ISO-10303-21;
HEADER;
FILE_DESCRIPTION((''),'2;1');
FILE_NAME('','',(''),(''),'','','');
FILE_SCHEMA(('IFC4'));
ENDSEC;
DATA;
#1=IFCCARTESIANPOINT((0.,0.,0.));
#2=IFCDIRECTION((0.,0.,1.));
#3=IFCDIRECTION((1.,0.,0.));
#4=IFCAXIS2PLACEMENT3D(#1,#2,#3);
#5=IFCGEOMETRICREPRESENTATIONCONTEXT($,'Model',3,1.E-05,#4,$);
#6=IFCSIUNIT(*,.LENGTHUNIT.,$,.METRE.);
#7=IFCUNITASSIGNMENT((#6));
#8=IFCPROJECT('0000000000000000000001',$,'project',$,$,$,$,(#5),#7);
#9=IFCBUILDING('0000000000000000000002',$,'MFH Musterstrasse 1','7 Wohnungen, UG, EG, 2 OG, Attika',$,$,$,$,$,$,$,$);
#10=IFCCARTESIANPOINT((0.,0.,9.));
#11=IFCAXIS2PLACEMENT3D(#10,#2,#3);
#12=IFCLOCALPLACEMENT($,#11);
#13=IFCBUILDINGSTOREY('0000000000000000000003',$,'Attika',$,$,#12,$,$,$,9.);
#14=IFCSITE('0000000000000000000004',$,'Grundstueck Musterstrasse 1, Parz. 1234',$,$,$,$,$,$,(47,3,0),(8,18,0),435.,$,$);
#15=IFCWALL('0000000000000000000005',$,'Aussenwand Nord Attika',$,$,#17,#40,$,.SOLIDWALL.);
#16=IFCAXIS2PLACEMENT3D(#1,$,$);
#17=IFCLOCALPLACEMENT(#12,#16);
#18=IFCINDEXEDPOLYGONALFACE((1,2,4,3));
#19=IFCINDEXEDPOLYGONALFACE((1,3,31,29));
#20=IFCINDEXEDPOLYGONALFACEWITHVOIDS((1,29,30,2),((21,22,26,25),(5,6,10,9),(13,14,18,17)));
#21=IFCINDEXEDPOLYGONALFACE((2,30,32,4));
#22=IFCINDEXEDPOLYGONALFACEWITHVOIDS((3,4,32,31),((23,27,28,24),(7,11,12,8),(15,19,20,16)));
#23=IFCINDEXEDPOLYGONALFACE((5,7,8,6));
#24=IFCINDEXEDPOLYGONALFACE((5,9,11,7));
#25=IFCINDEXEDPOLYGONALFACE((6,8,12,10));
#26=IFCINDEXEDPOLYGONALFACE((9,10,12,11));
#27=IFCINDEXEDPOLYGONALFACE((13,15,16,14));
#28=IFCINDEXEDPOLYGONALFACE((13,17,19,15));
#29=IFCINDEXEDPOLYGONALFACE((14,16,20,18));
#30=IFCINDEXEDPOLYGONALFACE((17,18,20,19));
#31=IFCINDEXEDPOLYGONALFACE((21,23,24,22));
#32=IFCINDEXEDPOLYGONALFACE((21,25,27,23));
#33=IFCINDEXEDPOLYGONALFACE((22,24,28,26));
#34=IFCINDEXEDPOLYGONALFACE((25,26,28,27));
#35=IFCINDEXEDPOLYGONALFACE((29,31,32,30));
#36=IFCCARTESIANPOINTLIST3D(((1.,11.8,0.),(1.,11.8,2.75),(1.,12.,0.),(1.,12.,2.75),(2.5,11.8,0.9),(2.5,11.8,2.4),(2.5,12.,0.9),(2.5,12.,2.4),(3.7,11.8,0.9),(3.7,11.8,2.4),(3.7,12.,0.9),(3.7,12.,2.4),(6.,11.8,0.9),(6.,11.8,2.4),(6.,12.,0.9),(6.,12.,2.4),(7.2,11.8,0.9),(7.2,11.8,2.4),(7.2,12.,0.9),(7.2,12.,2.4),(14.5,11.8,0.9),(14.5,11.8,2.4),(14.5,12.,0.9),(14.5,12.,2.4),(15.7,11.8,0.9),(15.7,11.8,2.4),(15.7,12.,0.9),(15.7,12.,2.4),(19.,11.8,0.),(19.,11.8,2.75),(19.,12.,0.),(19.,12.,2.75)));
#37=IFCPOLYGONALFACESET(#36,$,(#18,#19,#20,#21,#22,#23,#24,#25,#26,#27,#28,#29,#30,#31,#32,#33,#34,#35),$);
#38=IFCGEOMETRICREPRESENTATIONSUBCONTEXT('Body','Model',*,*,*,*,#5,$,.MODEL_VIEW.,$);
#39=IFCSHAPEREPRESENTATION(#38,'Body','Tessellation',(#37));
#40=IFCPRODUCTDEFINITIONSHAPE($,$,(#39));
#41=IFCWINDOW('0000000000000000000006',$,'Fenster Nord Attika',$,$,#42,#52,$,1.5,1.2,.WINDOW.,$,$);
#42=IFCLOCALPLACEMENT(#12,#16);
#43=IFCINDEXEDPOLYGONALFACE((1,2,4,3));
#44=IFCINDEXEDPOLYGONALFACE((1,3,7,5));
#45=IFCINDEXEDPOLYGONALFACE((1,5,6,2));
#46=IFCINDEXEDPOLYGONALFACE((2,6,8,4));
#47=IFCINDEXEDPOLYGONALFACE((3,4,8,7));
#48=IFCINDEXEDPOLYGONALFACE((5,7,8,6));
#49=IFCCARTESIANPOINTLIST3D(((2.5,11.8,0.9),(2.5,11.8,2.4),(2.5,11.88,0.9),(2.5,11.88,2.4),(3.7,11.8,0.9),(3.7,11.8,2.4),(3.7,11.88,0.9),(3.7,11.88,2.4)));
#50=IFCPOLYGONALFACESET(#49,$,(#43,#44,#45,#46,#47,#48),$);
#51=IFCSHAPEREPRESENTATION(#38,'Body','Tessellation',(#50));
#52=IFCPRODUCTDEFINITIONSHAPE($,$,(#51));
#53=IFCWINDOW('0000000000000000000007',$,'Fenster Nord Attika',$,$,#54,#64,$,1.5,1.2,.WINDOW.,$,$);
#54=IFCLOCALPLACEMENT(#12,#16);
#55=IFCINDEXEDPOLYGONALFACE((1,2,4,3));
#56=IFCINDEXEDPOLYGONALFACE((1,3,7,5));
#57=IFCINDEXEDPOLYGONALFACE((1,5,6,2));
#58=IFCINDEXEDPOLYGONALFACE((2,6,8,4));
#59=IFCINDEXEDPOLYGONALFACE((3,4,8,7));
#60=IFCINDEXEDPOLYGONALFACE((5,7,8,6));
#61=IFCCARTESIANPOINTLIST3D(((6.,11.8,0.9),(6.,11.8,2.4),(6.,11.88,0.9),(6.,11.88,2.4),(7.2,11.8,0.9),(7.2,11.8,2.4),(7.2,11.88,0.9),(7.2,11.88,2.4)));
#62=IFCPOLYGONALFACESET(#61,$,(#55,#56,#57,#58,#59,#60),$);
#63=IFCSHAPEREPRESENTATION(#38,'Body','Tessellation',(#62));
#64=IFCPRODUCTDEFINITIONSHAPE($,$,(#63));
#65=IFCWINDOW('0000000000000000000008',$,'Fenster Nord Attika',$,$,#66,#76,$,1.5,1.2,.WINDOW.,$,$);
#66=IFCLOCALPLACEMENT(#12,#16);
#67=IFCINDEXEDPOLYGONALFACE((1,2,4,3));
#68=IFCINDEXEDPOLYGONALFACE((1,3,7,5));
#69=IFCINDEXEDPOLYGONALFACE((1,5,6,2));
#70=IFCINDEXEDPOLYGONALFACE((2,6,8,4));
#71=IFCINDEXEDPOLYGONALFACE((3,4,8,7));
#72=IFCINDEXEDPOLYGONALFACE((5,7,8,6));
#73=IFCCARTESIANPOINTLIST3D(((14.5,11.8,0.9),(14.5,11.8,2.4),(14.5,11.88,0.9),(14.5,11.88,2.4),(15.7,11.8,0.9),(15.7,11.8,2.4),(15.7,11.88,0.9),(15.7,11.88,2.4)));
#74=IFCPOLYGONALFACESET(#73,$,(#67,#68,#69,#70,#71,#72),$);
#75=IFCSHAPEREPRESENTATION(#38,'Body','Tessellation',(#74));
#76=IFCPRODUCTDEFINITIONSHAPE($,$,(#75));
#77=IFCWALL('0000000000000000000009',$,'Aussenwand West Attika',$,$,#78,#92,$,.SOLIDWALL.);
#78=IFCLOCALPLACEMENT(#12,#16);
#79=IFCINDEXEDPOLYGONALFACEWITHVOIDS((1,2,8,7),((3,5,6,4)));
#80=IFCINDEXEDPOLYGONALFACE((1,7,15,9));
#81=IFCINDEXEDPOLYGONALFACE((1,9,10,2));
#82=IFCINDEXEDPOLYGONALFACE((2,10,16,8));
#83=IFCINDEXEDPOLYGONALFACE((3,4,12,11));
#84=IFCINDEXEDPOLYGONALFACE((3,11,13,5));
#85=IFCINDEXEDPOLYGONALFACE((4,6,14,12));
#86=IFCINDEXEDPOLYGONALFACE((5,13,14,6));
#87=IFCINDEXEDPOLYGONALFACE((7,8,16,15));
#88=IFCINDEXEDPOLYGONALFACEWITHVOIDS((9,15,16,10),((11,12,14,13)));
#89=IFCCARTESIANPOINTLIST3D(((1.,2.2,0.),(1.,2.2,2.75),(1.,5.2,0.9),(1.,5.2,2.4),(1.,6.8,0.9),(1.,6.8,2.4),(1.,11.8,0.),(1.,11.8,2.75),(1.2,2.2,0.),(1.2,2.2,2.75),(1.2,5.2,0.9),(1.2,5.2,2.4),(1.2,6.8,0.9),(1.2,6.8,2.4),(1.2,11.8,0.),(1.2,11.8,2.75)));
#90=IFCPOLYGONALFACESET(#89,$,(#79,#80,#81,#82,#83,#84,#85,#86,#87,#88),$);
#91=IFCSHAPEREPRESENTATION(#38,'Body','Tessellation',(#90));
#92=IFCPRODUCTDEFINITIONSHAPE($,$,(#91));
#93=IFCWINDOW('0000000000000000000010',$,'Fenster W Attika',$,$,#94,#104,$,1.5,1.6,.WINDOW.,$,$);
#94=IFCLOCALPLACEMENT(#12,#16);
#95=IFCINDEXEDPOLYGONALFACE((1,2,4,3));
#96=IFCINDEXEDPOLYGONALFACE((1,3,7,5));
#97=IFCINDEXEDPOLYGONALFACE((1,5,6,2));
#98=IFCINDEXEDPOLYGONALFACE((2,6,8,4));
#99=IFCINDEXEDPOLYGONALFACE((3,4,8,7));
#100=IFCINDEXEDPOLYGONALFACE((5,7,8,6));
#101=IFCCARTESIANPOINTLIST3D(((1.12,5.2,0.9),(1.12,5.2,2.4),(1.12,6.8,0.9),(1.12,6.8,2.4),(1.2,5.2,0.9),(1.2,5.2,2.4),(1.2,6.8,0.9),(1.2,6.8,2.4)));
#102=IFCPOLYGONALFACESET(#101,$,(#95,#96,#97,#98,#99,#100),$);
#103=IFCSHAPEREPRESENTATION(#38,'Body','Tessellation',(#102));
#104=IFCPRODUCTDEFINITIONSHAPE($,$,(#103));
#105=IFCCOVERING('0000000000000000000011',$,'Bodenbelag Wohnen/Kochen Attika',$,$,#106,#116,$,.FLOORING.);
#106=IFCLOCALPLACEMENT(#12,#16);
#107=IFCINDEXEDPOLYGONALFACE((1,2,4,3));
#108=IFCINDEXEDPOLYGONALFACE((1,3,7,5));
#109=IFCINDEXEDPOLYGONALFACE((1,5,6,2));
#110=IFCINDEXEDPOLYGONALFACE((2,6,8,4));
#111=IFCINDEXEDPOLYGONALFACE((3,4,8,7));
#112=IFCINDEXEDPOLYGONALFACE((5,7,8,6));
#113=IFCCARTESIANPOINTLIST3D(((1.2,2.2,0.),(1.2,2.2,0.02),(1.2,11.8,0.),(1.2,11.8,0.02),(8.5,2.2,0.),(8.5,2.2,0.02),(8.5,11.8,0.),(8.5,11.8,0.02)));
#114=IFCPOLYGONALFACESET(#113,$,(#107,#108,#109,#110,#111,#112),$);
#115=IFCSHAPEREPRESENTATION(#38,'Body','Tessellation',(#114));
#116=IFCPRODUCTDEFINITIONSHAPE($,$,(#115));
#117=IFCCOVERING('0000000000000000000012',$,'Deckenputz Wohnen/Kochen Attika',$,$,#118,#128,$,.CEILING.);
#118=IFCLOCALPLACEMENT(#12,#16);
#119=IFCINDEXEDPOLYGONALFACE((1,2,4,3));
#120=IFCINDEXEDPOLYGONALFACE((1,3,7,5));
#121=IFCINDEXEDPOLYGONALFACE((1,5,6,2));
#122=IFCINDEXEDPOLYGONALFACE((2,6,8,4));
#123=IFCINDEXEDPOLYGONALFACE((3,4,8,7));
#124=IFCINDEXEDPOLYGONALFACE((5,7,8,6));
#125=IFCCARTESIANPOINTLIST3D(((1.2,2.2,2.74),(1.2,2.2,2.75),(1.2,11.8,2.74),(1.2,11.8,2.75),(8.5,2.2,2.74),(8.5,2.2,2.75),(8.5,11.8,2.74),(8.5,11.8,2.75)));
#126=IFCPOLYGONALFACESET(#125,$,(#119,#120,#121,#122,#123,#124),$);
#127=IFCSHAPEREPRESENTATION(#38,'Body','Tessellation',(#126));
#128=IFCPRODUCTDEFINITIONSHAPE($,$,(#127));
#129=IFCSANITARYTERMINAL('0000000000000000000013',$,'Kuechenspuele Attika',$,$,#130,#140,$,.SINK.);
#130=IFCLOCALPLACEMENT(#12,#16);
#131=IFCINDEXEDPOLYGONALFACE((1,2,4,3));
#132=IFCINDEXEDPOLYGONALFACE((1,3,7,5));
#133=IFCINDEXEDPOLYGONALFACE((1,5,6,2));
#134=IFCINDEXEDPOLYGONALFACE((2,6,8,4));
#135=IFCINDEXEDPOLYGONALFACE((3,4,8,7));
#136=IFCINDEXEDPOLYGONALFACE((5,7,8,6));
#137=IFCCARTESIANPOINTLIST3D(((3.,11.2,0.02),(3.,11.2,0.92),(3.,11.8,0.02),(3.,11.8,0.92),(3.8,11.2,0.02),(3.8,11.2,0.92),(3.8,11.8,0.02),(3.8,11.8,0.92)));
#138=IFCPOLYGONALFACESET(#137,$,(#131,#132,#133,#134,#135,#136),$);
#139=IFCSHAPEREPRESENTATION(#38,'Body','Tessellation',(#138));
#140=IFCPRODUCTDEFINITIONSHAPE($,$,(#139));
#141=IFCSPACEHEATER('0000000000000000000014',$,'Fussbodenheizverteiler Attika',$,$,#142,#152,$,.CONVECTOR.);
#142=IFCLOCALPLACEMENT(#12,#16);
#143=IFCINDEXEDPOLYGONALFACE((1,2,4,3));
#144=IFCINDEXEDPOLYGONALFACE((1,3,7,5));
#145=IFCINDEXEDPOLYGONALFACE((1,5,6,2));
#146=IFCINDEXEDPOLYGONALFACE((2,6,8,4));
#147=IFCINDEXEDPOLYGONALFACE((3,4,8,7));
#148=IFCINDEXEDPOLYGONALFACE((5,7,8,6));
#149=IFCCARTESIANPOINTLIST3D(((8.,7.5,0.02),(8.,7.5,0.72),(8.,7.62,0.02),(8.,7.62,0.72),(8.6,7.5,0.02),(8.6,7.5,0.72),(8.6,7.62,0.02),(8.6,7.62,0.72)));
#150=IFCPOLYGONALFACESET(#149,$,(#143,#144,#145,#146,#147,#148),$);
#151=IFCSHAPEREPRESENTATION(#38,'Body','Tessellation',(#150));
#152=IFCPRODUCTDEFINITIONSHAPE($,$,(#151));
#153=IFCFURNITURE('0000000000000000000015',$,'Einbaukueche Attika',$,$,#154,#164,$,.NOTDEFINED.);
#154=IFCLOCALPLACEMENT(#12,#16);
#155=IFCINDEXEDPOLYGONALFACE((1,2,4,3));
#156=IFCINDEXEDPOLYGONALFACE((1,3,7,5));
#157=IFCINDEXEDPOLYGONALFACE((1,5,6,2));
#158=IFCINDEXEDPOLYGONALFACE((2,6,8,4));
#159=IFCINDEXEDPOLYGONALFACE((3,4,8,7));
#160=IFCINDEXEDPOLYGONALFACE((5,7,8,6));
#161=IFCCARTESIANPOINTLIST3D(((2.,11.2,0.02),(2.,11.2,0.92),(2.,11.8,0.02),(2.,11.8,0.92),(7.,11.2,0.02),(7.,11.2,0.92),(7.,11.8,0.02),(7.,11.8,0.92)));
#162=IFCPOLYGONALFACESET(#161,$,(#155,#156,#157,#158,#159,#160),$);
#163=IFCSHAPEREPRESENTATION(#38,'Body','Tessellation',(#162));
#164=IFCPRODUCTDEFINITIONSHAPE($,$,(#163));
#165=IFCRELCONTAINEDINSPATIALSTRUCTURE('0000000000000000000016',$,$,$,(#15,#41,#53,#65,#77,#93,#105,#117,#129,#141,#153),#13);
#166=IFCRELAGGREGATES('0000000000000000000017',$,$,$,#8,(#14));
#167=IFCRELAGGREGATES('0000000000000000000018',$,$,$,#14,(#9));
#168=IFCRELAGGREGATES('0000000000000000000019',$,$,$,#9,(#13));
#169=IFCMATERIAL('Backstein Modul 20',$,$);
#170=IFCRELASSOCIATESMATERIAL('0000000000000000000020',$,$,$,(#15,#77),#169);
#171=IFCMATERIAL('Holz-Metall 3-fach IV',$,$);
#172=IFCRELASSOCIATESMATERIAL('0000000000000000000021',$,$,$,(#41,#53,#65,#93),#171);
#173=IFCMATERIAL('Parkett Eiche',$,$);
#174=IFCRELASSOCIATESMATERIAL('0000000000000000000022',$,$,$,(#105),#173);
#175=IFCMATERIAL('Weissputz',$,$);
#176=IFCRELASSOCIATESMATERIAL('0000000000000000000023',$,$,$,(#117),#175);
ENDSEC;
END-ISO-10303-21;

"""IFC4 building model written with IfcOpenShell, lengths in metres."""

from ifc_helpers import new_model, si_unit, frame, frame_2d, origin_with_axes, place, context, subcontext, project, spatial, rectangle, extrude, material, element, fill, save


model = new_model("IFC4")

# Units and contexts
model_context = context("Model", 3, precision=1e-05, world=origin_with_axes())
body_context = subcontext(model_context, "Body", "Model", "MODEL_VIEW")
ifc_project = project(units=[si_unit("LENGTHUNIT", "METRE")], contexts=[model_context])

# Site, building, storey
site = spatial("IfcSite", under=ifc_project, Name="Grundstueck Musterstrasse 1, Parz. 1234", RefLatitude=(47, 3, 0), RefLongitude=(8, 18, 0), RefElevation=435.0)
building = spatial("IfcBuilding", under=site, Name="MFH Musterstrasse 1", Description="7 Wohnungen, UG, EG, 2 OG, Attika")
storey_placement = place(None, frame((0.0, 0.0, 9.0), z_axis=(0.0, 0.0, 1.0), x_axis=(1.0, 0.0, 0.0)))
storey = spatial("IfcBuildingStorey", under=building, at=storey_placement, Name="Attika", Elevation=9.0)

# Wall, openings, windows
ifc_material_1 = material(Name="Backstein Modul 20")
wall_1_placement = place(storey_placement, frame((1.0, 11.8, 0.0), z_axis=(0.0, 0.0, 1.0), x_axis=(1.0, 0.0, 0.0)))
wall_1 = element("IfcWall", 1, at=wall_1_placement, inside=storey, material=ifc_material_1, Name="Aussenwand Nord Attika", PredefinedType="SOLIDWALL", context=body_context, shape_type="SweptSolid", body=[
    extrude(rectangle(XDim=18.0, YDim=0.2, at=frame_2d((9.0, 0.1))), origin_with_axes(), (0.0, 0.0, 1.0), 2.75),
])
opening_1_placement = place(wall_1_placement, frame((1.5, -0.01, 0.9), z_axis=(0.0, 0.0, 1.0), x_axis=(1.0, 0.0, 0.0)))
opening_1 = element("IfcOpeningElement", 2, at=opening_1_placement, cuts=wall_1, context=body_context, shape_type="SweptSolid", body=[
    extrude(rectangle(XDim=1.2, YDim=0.42, at=frame_2d((0.6, 0.21))), origin_with_axes(), (0.0, 0.0, 1.0), 1.5),
])
opening_2_placement = place(wall_1_placement, frame((5.0, -0.01, 0.9), z_axis=(0.0, 0.0, 1.0), x_axis=(1.0, 0.0, 0.0)))
opening_2 = element("IfcOpeningElement", 3, at=opening_2_placement, cuts=wall_1, context=body_context, shape_type="SweptSolid", body=[
    extrude(rectangle(XDim=1.2, YDim=0.42, at=frame_2d((0.6, 0.21))), origin_with_axes(), (0.0, 0.0, 1.0), 1.5),
])
opening_3_placement = place(wall_1_placement, frame((13.5, -0.01, 0.9), z_axis=(0.0, 0.0, 1.0), x_axis=(1.0, 0.0, 0.0)))
opening_3 = element("IfcOpeningElement", 4, at=opening_3_placement, cuts=wall_1, context=body_context, shape_type="SweptSolid", body=[
    extrude(rectangle(XDim=1.2, YDim=0.42, at=frame_2d((0.6, 0.21))), origin_with_axes(), (0.0, 0.0, 1.0), 1.5),
])
ifc_material_2 = material(Name="Holz-Metall 3-fach IV")
window_1_placement = place(storey_placement, frame((2.5, 11.8, 0.9), z_axis=(0.0, 0.0, 1.0), x_axis=(1.0, 0.0, 0.0)))
window_1 = element("IfcWindow", 5, at=window_1_placement, inside=storey, material=ifc_material_2, Name="Fenster Nord Attika", OverallHeight=1.5, OverallWidth=1.2, PredefinedType="WINDOW", context=body_context, shape_type="SweptSolid", body=[
    extrude(rectangle(XDim=1.2, YDim=0.08, at=frame_2d((0.6, 0.04))), origin_with_axes(), (0.0, 0.0, 1.0), 1.5),
])
fill(opening_1, window_1)
window_2_placement = place(storey_placement, frame((6.0, 11.8, 0.9), z_axis=(0.0, 0.0, 1.0), x_axis=(1.0, 0.0, 0.0)))
window_2 = element("IfcWindow", 6, at=window_2_placement, inside=storey, material=ifc_material_2, Name="Fenster Nord Attika", OverallHeight=1.5, OverallWidth=1.2, PredefinedType="WINDOW", context=body_context, shape_type="SweptSolid", body=[
    extrude(rectangle(XDim=1.2, YDim=0.08, at=frame_2d((0.6, 0.04))), origin_with_axes(), (0.0, 0.0, 1.0), 1.5),
])
fill(opening_2, window_2)
window_3_placement = place(storey_placement, frame((14.5, 11.8, 0.9), z_axis=(0.0, 0.0, 1.0), x_axis=(1.0, 0.0, 0.0)))
window_3 = element("IfcWindow", 7, at=window_3_placement, inside=storey, material=ifc_material_2, Name="Fenster Nord Attika", OverallHeight=1.5, OverallWidth=1.2, PredefinedType="WINDOW", context=body_context, shape_type="SweptSolid", body=[
    extrude(rectangle(XDim=1.2, YDim=0.08, at=frame_2d((0.6, 0.04))), origin_with_axes(), (0.0, 0.0, 1.0), 1.5),
])
fill(opening_3, window_3)

# Wall, opening, window
wall_2_placement = place(storey_placement, frame((1.0, 2.2, 0.0), z_axis=(0.0, 0.0, 1.0), x_axis=(1.0, 0.0, 0.0)))
wall_2 = element("IfcWall", 8, at=wall_2_placement, inside=storey, material=ifc_material_1, Name="Aussenwand West Attika", PredefinedType="SOLIDWALL", context=body_context, shape_type="SweptSolid", body=[
    extrude(rectangle(XDim=0.2, YDim=9.6, at=frame_2d((0.1, 4.8))), origin_with_axes(), (0.0, 0.0, 1.0), 2.75),
])
opening_4_placement = place(wall_2_placement, frame((-0.21, 3.0, 0.9), z_axis=(0.0, 0.0, 1.0), x_axis=(1.0, 0.0, 0.0)))
opening_4 = element("IfcOpeningElement", 9, at=opening_4_placement, cuts=wall_2, context=body_context, shape_type="SweptSolid", body=[
    extrude(rectangle(XDim=0.42, YDim=1.6, at=frame_2d((0.21, 0.8))), origin_with_axes(), (0.0, 0.0, 1.0), 1.5),
])
window_4_placement = place(storey_placement, frame((1.12, 5.2, 0.9), z_axis=(0.0, 0.0, 1.0), x_axis=(1.0, 0.0, 0.0)))
window_4 = element("IfcWindow", 10, at=window_4_placement, inside=storey, material=ifc_material_2, Name="Fenster W Attika", OverallHeight=1.5, OverallWidth=1.6, PredefinedType="WINDOW", context=body_context, shape_type="SweptSolid", body=[
    extrude(rectangle(XDim=0.08, YDim=1.6, at=frame_2d((0.04, 0.8))), origin_with_axes(), (0.0, 0.0, 1.0), 1.5),
])
fill(opening_4, window_4)

# Coverings
ifc_material_3 = material(Name="Parkett Eiche")
covering_1_placement = place(storey_placement, frame((1.2, 2.2, 0.0), z_axis=(0.0, 0.0, 1.0), x_axis=(1.0, 0.0, 0.0)))
element("IfcCovering", 11, at=covering_1_placement, inside=storey, material=ifc_material_3, Name="Bodenbelag Wohnen/Kochen Attika", PredefinedType="FLOORING", context=body_context, shape_type="SweptSolid", body=[
    extrude(rectangle(XDim=7.3, YDim=9.6, at=frame_2d((3.65, 4.8))), origin_with_axes(), (0.0, 0.0, 1.0), 0.02),
])
ifc_material_4 = material(Name="Weissputz")
covering_2_placement = place(storey_placement, frame((1.2, 2.2, 2.74), z_axis=(0.0, 0.0, 1.0), x_axis=(1.0, 0.0, 0.0)))
element("IfcCovering", 12, at=covering_2_placement, inside=storey, material=ifc_material_4, Name="Deckenputz Wohnen/Kochen Attika", PredefinedType="CEILING", context=body_context, shape_type="SweptSolid", body=[
    extrude(rectangle(XDim=7.3, YDim=9.6, at=frame_2d((3.65, 4.8))), origin_with_axes(), (0.0, 0.0, 1.0), 0.01),
])

# Sanitary terminal
sanitary_terminal_placement = place(storey_placement, frame((3.0, 11.2, 0.02), z_axis=(0.0, 0.0, 1.0), x_axis=(1.0, 0.0, 0.0)))
element("IfcSanitaryTerminal", 13, at=sanitary_terminal_placement, inside=storey, Name="Kuechenspuele Attika", PredefinedType="SINK", context=body_context, shape_type="SweptSolid", body=[
    extrude(rectangle(XDim=0.8, YDim=0.6, at=frame_2d((0.4, 0.3))), origin_with_axes(), (0.0, 0.0, 1.0), 0.9),
])

# Space heater
space_heater_placement = place(storey_placement, frame((8.0, 7.5, 0.02), z_axis=(0.0, 0.0, 1.0), x_axis=(1.0, 0.0, 0.0)))
element("IfcSpaceHeater", 14, at=space_heater_placement, inside=storey, Name="Fussbodenheizverteiler Attika", PredefinedType="CONVECTOR", context=body_context, shape_type="SweptSolid", body=[
    extrude(rectangle(XDim=0.6, YDim=0.12, at=frame_2d((0.3, 0.06))), origin_with_axes(), (0.0, 0.0, 1.0), 0.7),
])

# Furniture
furniture_placement = place(storey_placement, frame((2.0, 11.2, 0.02), z_axis=(0.0, 0.0, 1.0), x_axis=(1.0, 0.0, 0.0)))
element("IfcFurniture", 15, at=furniture_placement, inside=storey, Name="Einbaukueche Attika", PredefinedType="NOTDEFINED", context=body_context, shape_type="SweptSolid", body=[
    extrude(rectangle(XDim=5.0, YDim=0.6, at=frame_2d((2.5, 0.3))), origin_with_axes(), (0.0, 0.0, 1.0), 0.9),
])

save(model, "model.ifc")
